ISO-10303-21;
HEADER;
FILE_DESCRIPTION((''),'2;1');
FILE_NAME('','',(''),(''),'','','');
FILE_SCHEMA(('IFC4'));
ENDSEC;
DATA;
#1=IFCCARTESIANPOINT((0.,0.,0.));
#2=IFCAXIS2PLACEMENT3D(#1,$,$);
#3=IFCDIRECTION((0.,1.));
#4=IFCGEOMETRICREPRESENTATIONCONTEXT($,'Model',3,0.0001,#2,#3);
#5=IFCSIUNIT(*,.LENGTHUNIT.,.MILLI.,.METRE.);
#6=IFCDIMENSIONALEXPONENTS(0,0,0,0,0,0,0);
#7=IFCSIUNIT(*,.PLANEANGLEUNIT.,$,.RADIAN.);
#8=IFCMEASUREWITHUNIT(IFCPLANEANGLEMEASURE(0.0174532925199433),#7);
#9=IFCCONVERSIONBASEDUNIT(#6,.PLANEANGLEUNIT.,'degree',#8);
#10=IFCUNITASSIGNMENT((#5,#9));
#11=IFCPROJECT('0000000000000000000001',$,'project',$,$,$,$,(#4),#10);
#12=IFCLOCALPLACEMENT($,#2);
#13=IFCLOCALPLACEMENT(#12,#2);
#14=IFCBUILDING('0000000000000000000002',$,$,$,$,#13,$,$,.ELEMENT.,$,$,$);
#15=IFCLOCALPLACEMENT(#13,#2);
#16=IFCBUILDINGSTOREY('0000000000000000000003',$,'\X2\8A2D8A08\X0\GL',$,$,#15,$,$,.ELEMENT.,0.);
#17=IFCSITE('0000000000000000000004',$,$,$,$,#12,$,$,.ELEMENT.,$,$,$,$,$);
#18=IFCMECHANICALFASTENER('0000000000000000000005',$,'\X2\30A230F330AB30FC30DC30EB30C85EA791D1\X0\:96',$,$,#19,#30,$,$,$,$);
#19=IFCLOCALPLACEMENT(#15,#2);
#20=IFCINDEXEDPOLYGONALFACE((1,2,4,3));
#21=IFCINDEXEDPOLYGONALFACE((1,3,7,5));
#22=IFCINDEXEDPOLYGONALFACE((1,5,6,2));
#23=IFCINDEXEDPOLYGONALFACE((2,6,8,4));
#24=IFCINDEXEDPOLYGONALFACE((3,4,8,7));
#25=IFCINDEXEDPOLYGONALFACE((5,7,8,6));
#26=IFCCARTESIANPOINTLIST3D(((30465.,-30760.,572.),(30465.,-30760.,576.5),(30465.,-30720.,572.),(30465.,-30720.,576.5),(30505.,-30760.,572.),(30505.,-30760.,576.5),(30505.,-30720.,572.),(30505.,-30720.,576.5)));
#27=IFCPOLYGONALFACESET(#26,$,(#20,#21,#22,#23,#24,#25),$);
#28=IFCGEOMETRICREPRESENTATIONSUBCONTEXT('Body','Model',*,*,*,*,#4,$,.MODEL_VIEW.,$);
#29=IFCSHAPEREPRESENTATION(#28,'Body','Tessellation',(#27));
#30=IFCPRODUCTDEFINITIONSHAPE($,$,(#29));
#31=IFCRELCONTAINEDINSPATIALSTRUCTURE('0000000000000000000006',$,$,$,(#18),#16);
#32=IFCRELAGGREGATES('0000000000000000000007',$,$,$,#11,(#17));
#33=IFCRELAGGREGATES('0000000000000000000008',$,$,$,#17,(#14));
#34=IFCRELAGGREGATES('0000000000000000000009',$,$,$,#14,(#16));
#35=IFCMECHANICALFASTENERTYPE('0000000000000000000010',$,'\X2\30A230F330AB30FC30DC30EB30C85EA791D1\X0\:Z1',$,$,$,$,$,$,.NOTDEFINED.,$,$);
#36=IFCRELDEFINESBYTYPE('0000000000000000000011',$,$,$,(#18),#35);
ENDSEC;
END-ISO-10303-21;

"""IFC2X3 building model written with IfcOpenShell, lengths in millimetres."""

from ifc_helpers import new_model, entity, si_unit, converted_unit, direction, frame, origin, origin_with_axes, origin_2d, place, context, subcontext, project, spatial, rectangle, extrude, type_object, element, save


model = new_model("IFC2X3")

# Units and contexts
model_context = context("Model", 3, precision=0.0001, world=origin(), true_north=direction((0.0, 1.0)))
body_context = subcontext(model_context, "Body", "Model", "MODEL_VIEW")
ifc_project = project(units=[si_unit("LENGTHUNIT", "METRE", prefix="MILLI"), converted_unit("PLANEANGLEUNIT", "degree", entity("IfcPlaneAngleMeasure", 0.0174532925199433), si_unit("PLANEANGLEUNIT", "RADIAN"), dimensions=[0, 0, 0, 0, 0, 0, 0])], contexts=[model_context])

# Site, building, storey
site_placement = place(None, origin())
site = spatial("IfcSite", under=ifc_project, at=site_placement, CompositionType="ELEMENT")
building_placement = place(site_placement, origin())
building = spatial("IfcBuilding", under=site, at=building_placement, CompositionType="ELEMENT")
storey_placement = place(building_placement, origin())
storey = spatial("IfcBuildingStorey", under=building, at=storey_placement, Name="設計GL", CompositionType="ELEMENT", Elevation=0.0)

# Mechanical fastener
mechanical_fastener_type_1 = type_object("IfcMechanicalFastenerType", Name="アンカーボルト座金:Z1")
mechanical_fastener_1_placement = place(storey_placement, frame((30485.0, -30740.0, 572.0)))
element("IfcMechanicalFastener", 1, at=mechanical_fastener_1_placement, inside=storey, type_object=mechanical_fastener_type_1, Name="アンカーボルト座金:96", context=body_context, shape_type="SweptSolid", body=[
    extrude(rectangle(XDim=40.0, YDim=40.0, at=origin_2d()), origin_with_axes(), (0.0, 0.0, 1.0), 4.5),
])

save(model, "model.ifc")
